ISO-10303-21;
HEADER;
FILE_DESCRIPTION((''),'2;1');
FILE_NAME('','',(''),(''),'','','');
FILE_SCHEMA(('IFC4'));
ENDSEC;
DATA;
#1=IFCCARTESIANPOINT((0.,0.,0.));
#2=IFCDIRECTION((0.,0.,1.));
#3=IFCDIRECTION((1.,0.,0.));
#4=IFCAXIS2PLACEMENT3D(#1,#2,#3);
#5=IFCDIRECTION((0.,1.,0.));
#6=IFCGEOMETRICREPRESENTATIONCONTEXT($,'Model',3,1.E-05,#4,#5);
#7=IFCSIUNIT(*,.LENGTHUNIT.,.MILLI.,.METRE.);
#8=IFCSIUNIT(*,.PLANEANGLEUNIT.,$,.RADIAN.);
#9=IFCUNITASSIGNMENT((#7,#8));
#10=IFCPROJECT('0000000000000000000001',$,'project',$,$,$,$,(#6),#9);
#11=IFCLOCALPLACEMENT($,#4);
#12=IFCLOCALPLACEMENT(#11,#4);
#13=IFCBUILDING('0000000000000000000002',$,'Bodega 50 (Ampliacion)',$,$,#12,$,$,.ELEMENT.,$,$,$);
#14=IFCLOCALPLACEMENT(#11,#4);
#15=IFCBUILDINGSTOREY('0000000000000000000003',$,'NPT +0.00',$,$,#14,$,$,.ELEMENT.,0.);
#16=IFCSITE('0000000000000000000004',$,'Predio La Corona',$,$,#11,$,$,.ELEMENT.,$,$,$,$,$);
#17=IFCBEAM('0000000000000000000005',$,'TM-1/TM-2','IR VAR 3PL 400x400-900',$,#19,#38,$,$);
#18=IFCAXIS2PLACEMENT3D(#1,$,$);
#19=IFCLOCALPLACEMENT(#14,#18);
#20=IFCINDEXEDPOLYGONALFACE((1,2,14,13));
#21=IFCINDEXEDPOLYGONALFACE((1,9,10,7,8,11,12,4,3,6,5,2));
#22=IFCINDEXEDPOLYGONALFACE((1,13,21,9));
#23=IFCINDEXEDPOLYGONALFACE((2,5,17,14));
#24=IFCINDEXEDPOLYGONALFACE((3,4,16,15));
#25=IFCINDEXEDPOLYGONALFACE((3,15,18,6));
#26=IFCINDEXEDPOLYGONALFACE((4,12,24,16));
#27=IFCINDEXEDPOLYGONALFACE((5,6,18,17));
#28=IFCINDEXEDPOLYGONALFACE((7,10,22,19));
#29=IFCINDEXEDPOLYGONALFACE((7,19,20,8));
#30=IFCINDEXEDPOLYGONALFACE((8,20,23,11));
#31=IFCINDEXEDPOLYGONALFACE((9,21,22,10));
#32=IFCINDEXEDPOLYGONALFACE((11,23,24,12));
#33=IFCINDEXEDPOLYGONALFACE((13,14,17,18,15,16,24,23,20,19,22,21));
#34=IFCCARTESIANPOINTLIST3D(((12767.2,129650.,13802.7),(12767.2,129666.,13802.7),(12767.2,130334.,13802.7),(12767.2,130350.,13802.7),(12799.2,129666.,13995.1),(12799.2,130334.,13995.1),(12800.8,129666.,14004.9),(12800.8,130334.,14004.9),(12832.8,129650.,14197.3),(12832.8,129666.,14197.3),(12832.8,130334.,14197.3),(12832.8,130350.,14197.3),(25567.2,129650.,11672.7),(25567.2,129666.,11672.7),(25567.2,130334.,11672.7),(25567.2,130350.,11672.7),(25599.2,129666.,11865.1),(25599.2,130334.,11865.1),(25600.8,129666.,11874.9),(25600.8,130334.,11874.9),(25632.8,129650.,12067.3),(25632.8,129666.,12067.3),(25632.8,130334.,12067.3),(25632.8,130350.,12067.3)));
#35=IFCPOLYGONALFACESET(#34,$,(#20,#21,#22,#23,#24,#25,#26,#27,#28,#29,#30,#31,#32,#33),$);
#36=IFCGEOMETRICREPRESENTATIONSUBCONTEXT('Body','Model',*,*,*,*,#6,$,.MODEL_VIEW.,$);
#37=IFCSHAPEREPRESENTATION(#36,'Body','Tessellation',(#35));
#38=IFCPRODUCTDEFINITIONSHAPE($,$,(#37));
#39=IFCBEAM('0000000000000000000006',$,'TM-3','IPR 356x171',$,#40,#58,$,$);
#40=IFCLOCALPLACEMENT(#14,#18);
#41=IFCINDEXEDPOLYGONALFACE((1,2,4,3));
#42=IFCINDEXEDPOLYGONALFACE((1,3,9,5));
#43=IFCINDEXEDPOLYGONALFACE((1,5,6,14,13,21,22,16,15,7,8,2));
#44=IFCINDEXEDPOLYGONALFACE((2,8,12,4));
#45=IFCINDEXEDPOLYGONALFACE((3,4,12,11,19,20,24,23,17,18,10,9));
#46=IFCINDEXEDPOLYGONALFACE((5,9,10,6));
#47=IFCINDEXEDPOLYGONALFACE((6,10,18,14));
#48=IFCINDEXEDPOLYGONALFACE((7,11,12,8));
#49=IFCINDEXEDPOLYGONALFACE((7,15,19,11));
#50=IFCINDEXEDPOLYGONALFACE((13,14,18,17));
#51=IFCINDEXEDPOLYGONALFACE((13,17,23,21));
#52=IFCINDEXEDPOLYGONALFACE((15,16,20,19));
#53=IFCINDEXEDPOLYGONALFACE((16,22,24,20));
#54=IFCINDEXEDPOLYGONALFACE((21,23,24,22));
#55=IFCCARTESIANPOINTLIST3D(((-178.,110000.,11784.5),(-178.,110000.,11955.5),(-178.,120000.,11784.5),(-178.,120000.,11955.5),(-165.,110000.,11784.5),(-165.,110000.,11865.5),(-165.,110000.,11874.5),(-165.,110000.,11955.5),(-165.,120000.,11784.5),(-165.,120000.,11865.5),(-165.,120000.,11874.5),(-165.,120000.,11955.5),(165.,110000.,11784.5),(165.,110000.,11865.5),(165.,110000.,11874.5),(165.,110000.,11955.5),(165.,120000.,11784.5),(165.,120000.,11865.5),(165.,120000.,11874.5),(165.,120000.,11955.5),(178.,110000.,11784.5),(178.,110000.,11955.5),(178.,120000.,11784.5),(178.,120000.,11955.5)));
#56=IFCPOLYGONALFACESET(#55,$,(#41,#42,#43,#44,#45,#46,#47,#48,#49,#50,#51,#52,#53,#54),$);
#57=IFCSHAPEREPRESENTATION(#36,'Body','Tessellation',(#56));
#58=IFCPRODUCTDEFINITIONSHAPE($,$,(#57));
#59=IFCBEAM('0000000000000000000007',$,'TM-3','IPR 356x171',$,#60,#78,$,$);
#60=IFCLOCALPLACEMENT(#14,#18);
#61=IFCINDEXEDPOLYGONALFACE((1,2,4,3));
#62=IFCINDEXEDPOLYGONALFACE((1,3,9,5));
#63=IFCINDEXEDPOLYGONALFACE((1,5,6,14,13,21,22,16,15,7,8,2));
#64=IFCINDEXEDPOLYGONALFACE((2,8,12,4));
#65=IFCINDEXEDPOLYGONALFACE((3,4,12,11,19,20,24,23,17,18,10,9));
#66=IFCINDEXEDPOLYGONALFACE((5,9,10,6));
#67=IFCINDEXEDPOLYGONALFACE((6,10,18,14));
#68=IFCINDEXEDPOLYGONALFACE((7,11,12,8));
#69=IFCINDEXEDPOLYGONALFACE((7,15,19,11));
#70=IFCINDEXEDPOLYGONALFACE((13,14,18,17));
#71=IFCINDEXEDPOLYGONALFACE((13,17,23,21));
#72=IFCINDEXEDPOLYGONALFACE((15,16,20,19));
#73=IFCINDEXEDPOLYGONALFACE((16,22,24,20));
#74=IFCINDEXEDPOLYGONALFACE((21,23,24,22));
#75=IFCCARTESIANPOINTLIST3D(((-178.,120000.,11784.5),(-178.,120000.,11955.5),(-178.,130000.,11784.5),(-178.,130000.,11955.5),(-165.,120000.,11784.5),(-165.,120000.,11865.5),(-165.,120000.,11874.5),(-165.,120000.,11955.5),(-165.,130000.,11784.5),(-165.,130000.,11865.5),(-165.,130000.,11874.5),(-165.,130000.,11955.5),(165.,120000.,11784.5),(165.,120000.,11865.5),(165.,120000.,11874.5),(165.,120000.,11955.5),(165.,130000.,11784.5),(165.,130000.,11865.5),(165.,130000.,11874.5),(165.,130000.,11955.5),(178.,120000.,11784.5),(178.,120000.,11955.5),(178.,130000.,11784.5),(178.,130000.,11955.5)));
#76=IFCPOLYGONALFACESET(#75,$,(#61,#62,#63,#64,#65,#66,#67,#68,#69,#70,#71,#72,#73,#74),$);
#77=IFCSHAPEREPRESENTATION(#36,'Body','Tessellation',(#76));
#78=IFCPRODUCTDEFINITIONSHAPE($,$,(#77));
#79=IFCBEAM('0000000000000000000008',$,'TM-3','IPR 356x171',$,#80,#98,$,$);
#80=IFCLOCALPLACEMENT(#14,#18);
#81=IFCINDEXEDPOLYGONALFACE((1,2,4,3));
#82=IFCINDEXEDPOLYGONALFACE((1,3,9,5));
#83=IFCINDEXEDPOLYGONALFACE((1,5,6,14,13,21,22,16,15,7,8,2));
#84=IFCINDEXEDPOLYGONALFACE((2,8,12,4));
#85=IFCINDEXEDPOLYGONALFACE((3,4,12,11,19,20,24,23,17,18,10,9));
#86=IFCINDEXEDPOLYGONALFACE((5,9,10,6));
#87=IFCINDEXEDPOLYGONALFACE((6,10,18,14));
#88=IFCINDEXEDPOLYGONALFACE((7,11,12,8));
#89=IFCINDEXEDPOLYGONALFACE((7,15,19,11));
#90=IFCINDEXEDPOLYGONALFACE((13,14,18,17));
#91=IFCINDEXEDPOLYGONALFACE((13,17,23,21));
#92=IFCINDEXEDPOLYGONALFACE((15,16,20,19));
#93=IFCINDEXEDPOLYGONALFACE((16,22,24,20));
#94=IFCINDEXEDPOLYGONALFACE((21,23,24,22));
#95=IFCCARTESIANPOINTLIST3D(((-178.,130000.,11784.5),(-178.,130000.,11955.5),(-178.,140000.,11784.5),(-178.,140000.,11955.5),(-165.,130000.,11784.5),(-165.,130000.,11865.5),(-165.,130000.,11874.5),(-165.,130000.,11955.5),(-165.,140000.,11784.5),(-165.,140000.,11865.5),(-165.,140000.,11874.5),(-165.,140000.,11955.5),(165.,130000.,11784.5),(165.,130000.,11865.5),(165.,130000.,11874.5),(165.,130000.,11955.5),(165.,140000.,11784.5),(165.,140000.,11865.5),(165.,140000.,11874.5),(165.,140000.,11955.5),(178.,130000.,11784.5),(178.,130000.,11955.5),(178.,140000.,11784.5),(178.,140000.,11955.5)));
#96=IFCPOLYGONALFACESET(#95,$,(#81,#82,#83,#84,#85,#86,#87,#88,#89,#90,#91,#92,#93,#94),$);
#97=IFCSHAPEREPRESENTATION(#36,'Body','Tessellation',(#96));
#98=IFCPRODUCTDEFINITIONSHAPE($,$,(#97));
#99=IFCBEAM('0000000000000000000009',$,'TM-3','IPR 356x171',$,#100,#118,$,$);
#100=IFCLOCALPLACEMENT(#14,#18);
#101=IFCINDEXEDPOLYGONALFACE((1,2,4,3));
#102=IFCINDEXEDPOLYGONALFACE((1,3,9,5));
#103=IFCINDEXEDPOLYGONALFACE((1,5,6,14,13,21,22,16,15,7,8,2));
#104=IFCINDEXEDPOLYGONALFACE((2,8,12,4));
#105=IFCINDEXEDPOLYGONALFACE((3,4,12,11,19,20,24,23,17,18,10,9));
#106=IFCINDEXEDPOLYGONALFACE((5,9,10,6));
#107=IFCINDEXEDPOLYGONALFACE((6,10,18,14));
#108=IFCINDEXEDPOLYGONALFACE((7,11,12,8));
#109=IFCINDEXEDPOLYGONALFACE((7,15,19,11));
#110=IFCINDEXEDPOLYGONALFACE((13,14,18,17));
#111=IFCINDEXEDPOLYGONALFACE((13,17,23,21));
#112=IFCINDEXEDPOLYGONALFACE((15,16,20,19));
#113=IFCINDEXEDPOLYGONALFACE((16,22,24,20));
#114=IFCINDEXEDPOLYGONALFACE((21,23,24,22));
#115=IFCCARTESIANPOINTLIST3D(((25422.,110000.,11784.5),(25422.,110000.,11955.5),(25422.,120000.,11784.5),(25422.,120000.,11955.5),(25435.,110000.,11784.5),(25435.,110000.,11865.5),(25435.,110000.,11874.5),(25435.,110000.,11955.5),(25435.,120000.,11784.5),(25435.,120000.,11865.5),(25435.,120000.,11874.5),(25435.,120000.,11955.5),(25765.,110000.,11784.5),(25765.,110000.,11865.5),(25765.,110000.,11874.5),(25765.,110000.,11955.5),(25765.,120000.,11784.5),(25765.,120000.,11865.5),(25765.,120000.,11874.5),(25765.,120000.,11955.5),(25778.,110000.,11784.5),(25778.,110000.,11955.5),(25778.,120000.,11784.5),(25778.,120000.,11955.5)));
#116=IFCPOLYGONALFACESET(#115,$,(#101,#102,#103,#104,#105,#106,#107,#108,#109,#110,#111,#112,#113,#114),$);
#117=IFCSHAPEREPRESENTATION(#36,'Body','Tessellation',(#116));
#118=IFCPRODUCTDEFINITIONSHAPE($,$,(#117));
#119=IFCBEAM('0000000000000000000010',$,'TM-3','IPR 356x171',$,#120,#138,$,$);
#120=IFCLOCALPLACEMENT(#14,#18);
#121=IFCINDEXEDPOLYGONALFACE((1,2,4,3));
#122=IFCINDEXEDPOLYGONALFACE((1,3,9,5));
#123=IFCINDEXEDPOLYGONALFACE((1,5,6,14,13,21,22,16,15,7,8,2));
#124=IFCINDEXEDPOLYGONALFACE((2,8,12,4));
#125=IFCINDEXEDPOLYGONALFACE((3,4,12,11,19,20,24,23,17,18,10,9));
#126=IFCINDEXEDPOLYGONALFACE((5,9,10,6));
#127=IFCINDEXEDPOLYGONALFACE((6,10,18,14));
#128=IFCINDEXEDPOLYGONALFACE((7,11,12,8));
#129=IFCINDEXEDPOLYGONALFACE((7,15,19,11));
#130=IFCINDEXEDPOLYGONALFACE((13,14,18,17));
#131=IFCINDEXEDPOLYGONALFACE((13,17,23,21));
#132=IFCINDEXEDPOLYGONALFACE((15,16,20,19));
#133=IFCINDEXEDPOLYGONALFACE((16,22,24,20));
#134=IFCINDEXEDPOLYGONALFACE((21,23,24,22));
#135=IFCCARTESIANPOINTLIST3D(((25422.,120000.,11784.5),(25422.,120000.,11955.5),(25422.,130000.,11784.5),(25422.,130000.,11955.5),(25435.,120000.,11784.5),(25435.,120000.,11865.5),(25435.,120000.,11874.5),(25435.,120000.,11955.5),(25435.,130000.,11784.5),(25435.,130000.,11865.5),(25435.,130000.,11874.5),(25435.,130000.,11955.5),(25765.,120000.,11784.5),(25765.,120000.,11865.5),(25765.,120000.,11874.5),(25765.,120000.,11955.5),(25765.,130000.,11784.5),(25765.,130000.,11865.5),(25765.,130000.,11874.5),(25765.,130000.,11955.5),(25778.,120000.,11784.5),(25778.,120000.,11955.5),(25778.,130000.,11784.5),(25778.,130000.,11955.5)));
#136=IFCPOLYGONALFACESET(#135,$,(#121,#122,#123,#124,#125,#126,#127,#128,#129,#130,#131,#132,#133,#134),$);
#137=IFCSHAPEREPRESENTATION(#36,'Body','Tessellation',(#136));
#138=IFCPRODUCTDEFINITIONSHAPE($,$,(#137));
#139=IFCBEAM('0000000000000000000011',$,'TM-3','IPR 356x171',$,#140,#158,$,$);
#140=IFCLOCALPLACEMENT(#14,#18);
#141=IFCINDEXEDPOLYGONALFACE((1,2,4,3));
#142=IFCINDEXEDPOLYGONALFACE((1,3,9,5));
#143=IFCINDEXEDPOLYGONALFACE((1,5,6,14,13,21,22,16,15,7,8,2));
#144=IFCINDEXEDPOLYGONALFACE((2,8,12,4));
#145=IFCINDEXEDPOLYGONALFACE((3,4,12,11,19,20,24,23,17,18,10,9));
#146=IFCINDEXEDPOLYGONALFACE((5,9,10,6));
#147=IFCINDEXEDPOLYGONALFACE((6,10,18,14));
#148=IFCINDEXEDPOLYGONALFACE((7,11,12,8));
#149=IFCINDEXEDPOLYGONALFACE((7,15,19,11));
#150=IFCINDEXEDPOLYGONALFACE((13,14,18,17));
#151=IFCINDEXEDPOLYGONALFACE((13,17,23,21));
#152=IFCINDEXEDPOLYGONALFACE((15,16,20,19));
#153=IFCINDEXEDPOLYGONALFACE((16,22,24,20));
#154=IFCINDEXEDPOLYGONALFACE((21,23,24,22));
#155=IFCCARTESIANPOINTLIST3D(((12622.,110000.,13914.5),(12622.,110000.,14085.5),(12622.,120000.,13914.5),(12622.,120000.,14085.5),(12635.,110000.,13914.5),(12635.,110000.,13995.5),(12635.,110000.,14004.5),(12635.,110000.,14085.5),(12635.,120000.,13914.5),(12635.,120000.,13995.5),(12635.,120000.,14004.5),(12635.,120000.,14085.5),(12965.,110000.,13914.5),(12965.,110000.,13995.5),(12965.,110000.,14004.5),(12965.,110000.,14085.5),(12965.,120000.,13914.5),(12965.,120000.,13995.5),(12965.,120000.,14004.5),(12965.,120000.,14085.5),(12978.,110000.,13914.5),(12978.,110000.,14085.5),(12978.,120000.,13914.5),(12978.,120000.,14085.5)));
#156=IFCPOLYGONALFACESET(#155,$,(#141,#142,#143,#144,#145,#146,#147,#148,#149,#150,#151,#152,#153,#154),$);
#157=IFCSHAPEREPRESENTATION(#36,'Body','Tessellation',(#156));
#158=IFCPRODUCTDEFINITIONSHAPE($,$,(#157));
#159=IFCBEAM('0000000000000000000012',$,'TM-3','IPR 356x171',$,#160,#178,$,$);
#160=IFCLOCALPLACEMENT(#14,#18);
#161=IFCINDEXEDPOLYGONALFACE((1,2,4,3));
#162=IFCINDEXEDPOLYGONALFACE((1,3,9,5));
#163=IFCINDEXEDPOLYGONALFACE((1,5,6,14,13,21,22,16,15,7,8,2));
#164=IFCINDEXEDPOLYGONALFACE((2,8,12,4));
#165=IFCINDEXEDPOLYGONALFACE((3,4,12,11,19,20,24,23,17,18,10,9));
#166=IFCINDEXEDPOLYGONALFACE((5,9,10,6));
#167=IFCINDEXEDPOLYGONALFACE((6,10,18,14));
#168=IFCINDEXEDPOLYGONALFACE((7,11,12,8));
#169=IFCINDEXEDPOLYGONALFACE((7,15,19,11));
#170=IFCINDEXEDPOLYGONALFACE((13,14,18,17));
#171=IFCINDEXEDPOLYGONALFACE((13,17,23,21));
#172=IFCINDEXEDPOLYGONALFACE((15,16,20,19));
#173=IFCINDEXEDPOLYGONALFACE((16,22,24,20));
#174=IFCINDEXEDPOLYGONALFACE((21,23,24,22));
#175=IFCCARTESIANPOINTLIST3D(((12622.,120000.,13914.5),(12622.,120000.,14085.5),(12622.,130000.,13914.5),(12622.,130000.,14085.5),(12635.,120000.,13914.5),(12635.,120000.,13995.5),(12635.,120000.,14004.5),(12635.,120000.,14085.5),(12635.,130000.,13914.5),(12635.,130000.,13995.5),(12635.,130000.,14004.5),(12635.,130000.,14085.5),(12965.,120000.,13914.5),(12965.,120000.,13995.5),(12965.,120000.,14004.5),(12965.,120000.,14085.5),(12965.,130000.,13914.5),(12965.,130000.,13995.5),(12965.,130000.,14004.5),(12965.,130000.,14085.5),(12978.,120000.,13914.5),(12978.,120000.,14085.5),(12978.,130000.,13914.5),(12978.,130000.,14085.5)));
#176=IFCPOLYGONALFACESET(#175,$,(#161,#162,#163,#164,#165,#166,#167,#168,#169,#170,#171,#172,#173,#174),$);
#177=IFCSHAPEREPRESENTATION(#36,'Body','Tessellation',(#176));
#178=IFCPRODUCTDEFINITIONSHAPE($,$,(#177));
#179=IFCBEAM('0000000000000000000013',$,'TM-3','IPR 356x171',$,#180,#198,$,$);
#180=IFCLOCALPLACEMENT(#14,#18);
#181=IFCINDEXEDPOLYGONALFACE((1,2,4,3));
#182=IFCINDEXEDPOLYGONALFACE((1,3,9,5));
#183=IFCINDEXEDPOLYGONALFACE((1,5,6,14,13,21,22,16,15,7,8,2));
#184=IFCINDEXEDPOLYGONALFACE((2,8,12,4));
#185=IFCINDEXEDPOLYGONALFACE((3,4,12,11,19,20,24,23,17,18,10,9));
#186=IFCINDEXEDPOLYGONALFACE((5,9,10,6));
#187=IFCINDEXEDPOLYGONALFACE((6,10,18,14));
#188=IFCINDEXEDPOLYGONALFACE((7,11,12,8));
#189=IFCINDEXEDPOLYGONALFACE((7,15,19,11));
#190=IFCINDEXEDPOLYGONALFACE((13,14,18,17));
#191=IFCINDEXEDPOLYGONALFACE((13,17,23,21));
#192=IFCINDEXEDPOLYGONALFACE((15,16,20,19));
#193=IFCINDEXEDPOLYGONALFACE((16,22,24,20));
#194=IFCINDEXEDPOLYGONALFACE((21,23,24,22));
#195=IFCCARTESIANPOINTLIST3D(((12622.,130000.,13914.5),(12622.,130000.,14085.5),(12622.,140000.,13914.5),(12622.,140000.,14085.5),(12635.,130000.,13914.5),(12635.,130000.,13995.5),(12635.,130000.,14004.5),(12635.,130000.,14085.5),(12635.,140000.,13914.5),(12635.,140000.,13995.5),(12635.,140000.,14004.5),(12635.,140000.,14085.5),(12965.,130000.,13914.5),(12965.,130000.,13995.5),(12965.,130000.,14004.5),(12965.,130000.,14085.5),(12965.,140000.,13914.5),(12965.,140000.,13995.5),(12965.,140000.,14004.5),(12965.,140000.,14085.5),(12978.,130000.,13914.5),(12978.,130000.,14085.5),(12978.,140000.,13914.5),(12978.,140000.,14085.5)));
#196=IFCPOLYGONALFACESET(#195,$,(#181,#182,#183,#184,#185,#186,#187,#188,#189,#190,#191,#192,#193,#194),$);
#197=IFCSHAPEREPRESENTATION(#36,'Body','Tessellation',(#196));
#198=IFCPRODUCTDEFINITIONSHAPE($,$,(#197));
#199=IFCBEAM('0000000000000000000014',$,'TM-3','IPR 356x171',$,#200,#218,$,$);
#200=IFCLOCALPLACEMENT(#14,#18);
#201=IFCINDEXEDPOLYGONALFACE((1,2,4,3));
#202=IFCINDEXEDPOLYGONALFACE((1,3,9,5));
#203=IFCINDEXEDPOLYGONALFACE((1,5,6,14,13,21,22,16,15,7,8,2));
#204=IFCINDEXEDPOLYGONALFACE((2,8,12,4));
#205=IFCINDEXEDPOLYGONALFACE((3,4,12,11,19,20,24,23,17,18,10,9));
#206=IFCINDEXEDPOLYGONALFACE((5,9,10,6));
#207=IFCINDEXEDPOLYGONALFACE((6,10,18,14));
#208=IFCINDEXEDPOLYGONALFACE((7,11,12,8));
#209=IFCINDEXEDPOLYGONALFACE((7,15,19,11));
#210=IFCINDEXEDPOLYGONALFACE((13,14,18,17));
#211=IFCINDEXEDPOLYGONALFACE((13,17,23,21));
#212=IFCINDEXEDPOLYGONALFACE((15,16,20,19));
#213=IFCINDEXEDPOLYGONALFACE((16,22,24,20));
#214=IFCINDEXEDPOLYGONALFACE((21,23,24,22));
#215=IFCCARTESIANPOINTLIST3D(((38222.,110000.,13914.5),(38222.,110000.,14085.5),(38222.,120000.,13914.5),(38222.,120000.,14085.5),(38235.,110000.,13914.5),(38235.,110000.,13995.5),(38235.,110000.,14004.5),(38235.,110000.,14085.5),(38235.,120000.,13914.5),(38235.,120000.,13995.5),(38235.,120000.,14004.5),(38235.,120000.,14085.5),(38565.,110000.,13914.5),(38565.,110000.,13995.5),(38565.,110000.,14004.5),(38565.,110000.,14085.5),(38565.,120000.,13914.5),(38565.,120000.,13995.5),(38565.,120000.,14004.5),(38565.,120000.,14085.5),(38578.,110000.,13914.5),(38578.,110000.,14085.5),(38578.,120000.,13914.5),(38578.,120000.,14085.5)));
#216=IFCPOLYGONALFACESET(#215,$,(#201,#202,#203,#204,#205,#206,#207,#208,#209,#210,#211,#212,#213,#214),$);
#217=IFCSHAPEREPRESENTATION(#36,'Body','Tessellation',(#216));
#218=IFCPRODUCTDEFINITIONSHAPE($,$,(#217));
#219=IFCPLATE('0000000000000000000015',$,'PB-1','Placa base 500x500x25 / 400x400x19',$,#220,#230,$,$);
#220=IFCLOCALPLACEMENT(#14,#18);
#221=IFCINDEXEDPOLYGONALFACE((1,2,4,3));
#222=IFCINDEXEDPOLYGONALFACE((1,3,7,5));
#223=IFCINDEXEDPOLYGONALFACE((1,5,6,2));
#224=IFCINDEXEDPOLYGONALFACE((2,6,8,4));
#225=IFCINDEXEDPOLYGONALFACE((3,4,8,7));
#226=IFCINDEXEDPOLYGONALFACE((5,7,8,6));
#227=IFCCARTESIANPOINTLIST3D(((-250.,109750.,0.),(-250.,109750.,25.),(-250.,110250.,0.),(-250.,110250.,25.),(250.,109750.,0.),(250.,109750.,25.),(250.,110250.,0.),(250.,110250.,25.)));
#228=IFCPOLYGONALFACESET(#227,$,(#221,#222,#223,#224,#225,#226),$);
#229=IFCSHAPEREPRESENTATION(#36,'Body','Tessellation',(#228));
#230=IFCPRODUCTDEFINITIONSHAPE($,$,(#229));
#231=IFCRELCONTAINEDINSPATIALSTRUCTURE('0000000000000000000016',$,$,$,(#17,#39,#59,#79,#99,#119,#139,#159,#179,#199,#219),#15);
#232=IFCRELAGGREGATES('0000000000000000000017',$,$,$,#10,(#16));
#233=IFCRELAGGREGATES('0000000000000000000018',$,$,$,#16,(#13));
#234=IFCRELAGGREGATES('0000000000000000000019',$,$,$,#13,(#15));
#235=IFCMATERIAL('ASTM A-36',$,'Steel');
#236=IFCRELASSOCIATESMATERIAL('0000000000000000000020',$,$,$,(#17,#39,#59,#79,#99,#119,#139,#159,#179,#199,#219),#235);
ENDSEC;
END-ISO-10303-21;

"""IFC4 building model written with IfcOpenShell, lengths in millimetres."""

from ifc_helpers import new_model, si_unit, direction, frame, origin_with_axes, origin_2d, place, context, subcontext, project, spatial, rectangle, i_section, extrude, material, element, save


model = new_model("IFC4")

# Units and contexts
model_context = context("Model", 3, precision=1e-05, world=origin_with_axes(), true_north=direction((0.0, 1.0, 0.0)))
body_context = subcontext(model_context, "Body", "Model", "MODEL_VIEW")
ifc_project = project(units=[si_unit("LENGTHUNIT", "METRE", prefix="MILLI"), si_unit("PLANEANGLEUNIT", "RADIAN")], contexts=[model_context])

# Site, building, storey
site_placement = place(None, origin_with_axes())
site = spatial("IfcSite", under=ifc_project, at=site_placement, Name="Predio La Corona", CompositionType="ELEMENT")
building_placement = place(site_placement, origin_with_axes())
building = spatial("IfcBuilding", under=site, at=building_placement, Name="Bodega 50 (Ampliacion)", CompositionType="ELEMENT")
storey_placement = place(site_placement, origin_with_axes())
storey = spatial("IfcBuildingStorey", under=building, at=storey_placement, Name="NPT +0.00", CompositionType="ELEMENT", Elevation=0.0)

# Shared definitions
ifc_material = material(Name="ASTM A-36", Category="Steel")

# Beams
for number, where, z_axis, x_axis, name in (
    (1, (12800.0, 130000.0, 14000.0), (0.986436, 0.0, -0.164149), (-0.164149, 0.0, -0.986436), "TM-1/TM-2"),
):
    element("IfcBeam", number, at=place(storey_placement, frame(where, z_axis=z_axis, x_axis=x_axis)), inside=storey, material=ifc_material, Name=name, Description="IR VAR 3PL 400x400-900", context=body_context, shape_type="SweptSolid", body=[
        extrude(i_section(OverallWidth=400.0, OverallDepth=700.0, WebThickness=10.0, FlangeThickness=16.0, at=origin_2d()), origin_with_axes(), (0.0, 0.0, 1.0), 12976.0),
    ])
for number, where, z_axis, x_axis, name in (
    (2, (0.0, 110000.0, 11870.0), (0.0, 1.0, 0.0), (0.0, 0.0, 1.0), "TM-3"),
    (3, (0.0, 120000.0, 11870.0), (0.0, 1.0, 0.0), (0.0, 0.0, 1.0), "TM-3"),
    (4, (0.0, 130000.0, 11870.0), (0.0, 1.0, 0.0), (0.0, 0.0, 1.0), "TM-3"),
    (5, (25600.0, 110000.0, 11870.0), (0.0, 1.0, 0.0), (0.0, 0.0, 1.0), "TM-3"),
    (6, (25600.0, 120000.0, 11870.0), (0.0, 1.0, 0.0), (0.0, 0.0, 1.0), "TM-3"),
    (7, (12800.0, 110000.0, 14000.0), (0.0, 1.0, 0.0), (0.0, 0.0, 1.0), "TM-3"),
    (8, (12800.0, 120000.0, 14000.0), (0.0, 1.0, 0.0), (0.0, 0.0, 1.0), "TM-3"),
    (9, (12800.0, 130000.0, 14000.0), (0.0, 1.0, 0.0), (0.0, 0.0, 1.0), "TM-3"),
    (10, (38400.0, 110000.0, 14000.0), (0.0, 1.0, 0.0), (0.0, 0.0, 1.0), "TM-3"),
):
    element("IfcBeam", number, at=place(storey_placement, frame(where, z_axis=z_axis, x_axis=x_axis)), inside=storey, material=ifc_material, Name=name, Description="IPR 356x171", context=body_context, shape_type="SweptSolid", body=[
        extrude(i_section(OverallWidth=171.0, OverallDepth=356.0, WebThickness=9.0, FlangeThickness=13.0, at=origin_2d()), origin_with_axes(), (0.0, 0.0, 1.0), 10000.0),
    ])

# Plate
for number, where, z_axis, x_axis, name in (
    (11, (0.0, 110000.0, 0.0), (0.0, 0.0, 1.0), (1.0, 0.0, 0.0), "PB-1"),
):
    element("IfcPlate", number, at=place(storey_placement, frame(where, z_axis=z_axis, x_axis=x_axis)), inside=storey, material=ifc_material, Name=name, Description="Placa base 500x500x25 / 400x400x19", context=body_context, shape_type="SweptSolid", body=[
        extrude(rectangle(XDim=500.0, YDim=500.0, at=origin_2d()), origin_with_axes(), (0.0, 0.0, 1.0), 25.0),
    ])

save(model, "model.ifc")
